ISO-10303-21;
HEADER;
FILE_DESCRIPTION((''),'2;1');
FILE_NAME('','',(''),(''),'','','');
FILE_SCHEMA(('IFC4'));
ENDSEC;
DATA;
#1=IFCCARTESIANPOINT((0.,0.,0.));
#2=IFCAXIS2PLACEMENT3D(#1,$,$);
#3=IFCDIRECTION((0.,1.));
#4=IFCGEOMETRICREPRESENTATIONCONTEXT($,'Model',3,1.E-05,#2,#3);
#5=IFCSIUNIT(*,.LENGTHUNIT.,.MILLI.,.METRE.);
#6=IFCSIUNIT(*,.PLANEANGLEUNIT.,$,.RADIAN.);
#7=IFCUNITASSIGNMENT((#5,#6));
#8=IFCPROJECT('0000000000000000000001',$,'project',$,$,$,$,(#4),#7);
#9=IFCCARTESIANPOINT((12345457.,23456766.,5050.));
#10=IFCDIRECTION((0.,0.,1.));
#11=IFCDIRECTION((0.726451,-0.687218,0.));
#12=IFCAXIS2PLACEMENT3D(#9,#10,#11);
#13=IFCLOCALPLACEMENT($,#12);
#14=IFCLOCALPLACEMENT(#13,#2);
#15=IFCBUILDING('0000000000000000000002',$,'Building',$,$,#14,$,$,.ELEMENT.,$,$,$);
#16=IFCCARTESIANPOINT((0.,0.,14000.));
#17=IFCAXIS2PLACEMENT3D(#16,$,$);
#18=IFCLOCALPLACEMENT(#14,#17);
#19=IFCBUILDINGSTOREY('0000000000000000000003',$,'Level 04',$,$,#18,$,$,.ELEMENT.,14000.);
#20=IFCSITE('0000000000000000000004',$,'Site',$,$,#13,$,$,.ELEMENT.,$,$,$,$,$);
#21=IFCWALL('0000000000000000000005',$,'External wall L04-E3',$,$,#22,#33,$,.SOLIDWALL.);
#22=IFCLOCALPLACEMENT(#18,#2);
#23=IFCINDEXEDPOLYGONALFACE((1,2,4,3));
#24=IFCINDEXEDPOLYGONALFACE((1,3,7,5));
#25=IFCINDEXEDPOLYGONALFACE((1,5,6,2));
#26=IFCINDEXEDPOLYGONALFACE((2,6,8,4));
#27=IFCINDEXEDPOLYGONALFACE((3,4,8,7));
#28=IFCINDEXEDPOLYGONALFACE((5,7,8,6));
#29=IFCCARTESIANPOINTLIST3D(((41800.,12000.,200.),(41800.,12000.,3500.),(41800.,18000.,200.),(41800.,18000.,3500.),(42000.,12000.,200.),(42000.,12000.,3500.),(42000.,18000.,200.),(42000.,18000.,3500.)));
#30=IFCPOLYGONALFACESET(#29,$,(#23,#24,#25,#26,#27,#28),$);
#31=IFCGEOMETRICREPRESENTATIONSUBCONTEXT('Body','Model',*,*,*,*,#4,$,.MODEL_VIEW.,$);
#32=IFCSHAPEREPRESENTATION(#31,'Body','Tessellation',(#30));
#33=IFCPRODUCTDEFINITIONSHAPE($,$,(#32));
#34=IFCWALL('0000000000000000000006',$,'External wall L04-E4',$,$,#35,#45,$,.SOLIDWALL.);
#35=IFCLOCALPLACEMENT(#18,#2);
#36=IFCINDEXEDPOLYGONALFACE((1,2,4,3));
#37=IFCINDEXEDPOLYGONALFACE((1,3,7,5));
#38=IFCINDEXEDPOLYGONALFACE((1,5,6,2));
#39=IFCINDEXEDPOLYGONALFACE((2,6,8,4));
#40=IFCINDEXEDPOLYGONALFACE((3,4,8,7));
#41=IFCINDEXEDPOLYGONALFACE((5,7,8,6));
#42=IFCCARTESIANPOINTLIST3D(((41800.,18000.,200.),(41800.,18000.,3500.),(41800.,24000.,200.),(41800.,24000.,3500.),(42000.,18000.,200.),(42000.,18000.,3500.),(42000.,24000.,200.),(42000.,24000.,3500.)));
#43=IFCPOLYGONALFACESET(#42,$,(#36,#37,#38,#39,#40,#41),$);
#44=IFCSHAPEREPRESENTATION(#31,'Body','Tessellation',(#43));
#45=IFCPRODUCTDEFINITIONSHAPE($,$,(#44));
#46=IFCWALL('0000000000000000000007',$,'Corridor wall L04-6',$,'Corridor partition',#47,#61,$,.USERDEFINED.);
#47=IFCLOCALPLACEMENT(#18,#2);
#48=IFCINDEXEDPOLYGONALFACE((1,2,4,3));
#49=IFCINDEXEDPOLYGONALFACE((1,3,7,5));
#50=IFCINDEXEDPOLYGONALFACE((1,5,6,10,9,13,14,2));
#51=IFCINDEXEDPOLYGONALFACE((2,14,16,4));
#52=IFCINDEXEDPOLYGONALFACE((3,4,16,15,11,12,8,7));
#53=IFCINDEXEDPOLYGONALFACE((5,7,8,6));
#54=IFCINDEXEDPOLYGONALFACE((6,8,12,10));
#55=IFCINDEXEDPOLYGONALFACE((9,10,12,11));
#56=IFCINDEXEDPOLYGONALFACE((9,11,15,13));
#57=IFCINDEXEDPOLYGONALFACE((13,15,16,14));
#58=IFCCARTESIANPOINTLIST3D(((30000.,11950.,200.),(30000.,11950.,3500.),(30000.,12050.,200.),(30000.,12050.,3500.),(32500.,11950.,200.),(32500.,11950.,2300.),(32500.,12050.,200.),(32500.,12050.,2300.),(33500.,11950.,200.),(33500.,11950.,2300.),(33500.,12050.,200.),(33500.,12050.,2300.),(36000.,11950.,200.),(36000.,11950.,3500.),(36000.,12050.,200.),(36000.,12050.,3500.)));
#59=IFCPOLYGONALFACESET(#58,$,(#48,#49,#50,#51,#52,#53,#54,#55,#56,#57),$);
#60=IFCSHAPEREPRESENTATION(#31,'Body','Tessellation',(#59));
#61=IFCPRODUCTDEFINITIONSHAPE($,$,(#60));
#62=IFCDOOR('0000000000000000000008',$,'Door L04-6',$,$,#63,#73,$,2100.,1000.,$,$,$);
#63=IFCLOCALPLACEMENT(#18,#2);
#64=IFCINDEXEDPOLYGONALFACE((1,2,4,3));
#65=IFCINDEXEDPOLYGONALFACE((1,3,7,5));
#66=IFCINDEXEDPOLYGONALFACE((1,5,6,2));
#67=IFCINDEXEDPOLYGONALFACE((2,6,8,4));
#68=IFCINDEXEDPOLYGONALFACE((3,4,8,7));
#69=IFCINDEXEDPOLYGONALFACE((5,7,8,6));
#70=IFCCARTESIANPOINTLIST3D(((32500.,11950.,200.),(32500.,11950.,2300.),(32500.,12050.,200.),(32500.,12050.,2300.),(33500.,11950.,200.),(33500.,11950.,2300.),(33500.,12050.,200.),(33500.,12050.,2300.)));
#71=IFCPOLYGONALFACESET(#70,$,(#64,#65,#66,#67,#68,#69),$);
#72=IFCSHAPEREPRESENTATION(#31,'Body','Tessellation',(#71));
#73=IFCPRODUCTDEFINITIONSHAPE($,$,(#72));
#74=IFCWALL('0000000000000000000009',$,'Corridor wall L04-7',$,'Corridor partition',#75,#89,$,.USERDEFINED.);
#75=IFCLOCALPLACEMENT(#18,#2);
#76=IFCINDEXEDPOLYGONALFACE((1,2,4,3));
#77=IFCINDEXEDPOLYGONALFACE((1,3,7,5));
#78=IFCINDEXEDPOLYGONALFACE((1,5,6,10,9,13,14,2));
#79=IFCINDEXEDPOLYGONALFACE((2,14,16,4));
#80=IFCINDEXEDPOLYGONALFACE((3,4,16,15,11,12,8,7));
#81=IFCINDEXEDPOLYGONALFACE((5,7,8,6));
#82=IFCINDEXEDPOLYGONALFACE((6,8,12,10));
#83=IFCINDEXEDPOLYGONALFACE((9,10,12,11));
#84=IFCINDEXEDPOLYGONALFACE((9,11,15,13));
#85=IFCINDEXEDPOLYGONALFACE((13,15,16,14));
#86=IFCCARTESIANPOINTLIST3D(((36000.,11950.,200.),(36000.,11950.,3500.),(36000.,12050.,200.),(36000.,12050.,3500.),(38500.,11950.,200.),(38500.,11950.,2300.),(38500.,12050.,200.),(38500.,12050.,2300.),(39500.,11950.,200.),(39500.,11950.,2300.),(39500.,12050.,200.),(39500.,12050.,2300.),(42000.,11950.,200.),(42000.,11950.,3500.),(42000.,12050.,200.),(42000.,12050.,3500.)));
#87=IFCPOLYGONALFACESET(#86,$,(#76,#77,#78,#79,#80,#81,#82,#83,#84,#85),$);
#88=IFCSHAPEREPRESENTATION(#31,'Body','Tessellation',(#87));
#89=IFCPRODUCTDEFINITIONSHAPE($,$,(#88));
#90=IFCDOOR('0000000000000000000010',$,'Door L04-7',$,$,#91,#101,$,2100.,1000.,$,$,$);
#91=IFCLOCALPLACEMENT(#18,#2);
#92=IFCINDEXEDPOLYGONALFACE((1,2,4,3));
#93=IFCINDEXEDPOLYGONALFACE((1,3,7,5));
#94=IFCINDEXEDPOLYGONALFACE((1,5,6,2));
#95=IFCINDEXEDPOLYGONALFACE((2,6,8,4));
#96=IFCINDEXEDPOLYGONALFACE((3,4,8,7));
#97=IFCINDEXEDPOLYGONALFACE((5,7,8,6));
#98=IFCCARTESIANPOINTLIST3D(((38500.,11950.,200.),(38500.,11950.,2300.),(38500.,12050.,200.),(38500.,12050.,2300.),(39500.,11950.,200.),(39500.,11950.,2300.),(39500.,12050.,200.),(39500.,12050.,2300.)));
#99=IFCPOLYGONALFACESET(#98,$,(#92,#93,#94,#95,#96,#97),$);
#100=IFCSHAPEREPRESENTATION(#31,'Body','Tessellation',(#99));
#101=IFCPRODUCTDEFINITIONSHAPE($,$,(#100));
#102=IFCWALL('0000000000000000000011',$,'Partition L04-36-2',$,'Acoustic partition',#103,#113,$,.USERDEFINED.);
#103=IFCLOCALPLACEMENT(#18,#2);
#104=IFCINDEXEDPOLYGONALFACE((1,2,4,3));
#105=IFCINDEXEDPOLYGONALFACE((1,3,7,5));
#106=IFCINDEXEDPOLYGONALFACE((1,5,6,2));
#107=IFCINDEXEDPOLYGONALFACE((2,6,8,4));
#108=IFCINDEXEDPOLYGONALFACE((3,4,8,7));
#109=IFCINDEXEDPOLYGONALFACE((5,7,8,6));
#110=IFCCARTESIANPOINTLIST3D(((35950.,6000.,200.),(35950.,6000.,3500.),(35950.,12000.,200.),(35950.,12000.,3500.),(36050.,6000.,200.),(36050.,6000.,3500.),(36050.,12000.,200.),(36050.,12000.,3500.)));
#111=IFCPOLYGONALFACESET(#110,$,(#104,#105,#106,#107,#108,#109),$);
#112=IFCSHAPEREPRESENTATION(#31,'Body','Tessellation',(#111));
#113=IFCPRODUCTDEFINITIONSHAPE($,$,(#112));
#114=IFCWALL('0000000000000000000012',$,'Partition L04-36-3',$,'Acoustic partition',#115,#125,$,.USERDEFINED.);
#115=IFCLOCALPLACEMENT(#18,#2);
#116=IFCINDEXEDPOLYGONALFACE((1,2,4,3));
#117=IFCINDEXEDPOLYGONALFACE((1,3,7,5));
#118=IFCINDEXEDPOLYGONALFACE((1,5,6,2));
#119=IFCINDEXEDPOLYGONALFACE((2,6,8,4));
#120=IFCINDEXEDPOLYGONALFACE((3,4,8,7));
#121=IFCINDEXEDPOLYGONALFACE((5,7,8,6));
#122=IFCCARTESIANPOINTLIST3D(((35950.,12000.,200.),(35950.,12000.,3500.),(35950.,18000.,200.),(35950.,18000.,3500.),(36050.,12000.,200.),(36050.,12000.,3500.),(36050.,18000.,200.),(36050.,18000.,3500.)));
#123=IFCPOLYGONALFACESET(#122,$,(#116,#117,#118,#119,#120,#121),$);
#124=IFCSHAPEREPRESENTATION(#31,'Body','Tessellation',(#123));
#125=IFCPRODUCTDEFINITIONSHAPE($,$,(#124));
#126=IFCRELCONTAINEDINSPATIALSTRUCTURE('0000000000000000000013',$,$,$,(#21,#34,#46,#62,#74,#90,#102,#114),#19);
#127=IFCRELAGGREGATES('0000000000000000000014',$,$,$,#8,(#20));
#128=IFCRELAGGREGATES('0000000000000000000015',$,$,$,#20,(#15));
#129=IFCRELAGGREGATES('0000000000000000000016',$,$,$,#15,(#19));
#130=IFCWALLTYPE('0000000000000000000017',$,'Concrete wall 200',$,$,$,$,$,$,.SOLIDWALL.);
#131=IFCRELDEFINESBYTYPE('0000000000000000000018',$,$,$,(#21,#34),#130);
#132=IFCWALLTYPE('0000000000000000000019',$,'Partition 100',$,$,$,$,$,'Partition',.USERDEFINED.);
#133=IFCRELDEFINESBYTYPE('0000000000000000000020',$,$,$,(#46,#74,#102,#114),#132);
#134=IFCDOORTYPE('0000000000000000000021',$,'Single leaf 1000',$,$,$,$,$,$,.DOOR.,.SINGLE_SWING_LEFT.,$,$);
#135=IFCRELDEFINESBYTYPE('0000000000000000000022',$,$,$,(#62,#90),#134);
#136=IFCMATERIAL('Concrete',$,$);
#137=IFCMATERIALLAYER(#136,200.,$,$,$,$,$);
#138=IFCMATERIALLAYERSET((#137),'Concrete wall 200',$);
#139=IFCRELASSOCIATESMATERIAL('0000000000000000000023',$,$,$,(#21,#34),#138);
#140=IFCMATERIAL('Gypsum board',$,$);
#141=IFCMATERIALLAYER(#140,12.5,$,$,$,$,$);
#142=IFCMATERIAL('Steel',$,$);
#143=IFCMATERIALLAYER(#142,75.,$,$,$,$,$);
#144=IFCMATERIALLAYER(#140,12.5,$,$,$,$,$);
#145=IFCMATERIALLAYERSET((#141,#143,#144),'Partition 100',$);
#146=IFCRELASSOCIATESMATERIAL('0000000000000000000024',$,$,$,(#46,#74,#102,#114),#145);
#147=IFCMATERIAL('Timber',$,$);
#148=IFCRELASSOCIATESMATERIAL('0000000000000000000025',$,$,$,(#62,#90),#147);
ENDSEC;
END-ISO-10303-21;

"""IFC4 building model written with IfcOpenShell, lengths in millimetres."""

from ifc_helpers import new_model, si_unit, direction, frame, origin, place, context, subcontext, project, spatial, rectangle, extrude, source, transform, mapped, material, layer, layer_set, layer_usage, type_object, type_shapes, element, fill, save


model = new_model("IFC4")

# Units and contexts
model_context = context("Model", 3, precision=1e-05, world=origin(), true_north=direction((0.0, 1.0)))
body_context = subcontext(model_context, "Body", "Model", "MODEL_VIEW")
ifc_project = project(units=[si_unit("LENGTHUNIT", "METRE", prefix="MILLI"), si_unit("PLANEANGLEUNIT", "RADIAN")], contexts=[model_context])

# Site, building, storey
site_placement = place(None, frame((12345457.0, 23456766.0, 5050.0), z_axis=(0.0, 0.0, 1.0), x_axis=(0.726451, -0.687218, 0.0)))
site = spatial("IfcSite", under=ifc_project, at=site_placement, Name="Site", CompositionType="ELEMENT")
building_placement = place(site_placement, origin())
building = spatial("IfcBuilding", under=site, at=building_placement, Name="Building", CompositionType="ELEMENT")
storey_placement = place(building_placement, frame((0.0, 0.0, 14000.0)))
storey = spatial("IfcBuildingStorey", under=building, at=storey_placement, Name="Level 04", CompositionType="ELEMENT", Elevation=14000.0)

# Shared definitions
ifc_material_1 = material(Name="Steel")

# Shared definitions
ifc_material_2 = material(Name="Concrete")

# Walls
ifc_layer_1 = layer(ifc_material_2, 200.0)
ifc_layer_set_1 = layer_set([ifc_layer_1], Name="Concrete wall 200")
ifc_layer_usage_1 = layer_usage(ifc_layer_set_1, "AXIS2", "POSITIVE", 0.0)
wall_type_1 = type_object("IfcWallType", Name="Concrete wall 200", PredefinedType="SOLIDWALL")
for number, where, name in (
    (1, (41800.0, 12000.0, 200.0), "External wall L04-E3"),
    (2, (41800.0, 18000.0, 200.0), "External wall L04-E4"),
):
    element("IfcWall", number, at=place(storey_placement, frame(where)), inside=storey, type_object=wall_type_1, material=ifc_layer_usage_1, Name=name, PredefinedType="SOLIDWALL", context=body_context, shape_type="SweptSolid", body=[
        extrude(rectangle(XDim=200.0, YDim=6000.0), frame((100.0, 3000.0, 0.0)), (0.0, 0.0, 1.0), 3300.0),
    ])

# Walls, openings, doors
ifc_material_3 = material(Name="Gypsum board")
ifc_layer_2 = layer(ifc_material_3, 12.5)
ifc_layer_3 = layer(ifc_material_1, 75.0)
ifc_layer_4 = layer(ifc_material_3, 12.5)
ifc_layer_set_2 = layer_set([ifc_layer_2, ifc_layer_3, ifc_layer_4], Name="Partition 100")
ifc_layer_usage_2 = layer_usage(ifc_layer_set_2, "AXIS2", "POSITIVE", 0.0)
wall_type_2 = type_object("IfcWallType", Name="Partition 100", ElementType="Partition", PredefinedType="USERDEFINED")
wall_1_placement = place(storey_placement, frame((30000.0, 11950.0, 200.0)))
wall_1 = element("IfcWall", 3, at=wall_1_placement, inside=storey, type_object=wall_type_2, material=ifc_layer_usage_2, Name="Corridor wall L04-6", ObjectType="Corridor partition", PredefinedType="USERDEFINED", context=body_context, shape_type="SweptSolid", body=[
    extrude(rectangle(XDim=6000.0, YDim=100.0), frame((3000.0, 50.0, 0.0)), (0.0, 0.0, 1.0), 3300.0),
])
opening_1_placement = place(wall_1_placement, frame((2500.0, -50.0, 0.0)))
opening_1 = element("IfcOpeningElement", 4, at=opening_1_placement, cuts=wall_1, PredefinedType="OPENING", context=body_context, shape_type="SweptSolid", body=[
    extrude(rectangle(XDim=1000.0, YDim=200.0), frame((500.0, 100.0, 0.0)), (0.0, 0.0, 1.0), 2100.0),
])
ifc_material_4 = material(Name="Timber")
door_type = type_object("IfcDoorType", Name="Single leaf 1000", OperationType="SINGLE_SWING_LEFT", PredefinedType="DOOR")
shared_shape = source(origin(), body_context, "Body", "SweptSolid", [
    extrude(rectangle(XDim=1000.0, YDim=100.0), frame((500.0, 50.0, 0.0)), (0.0, 0.0, 1.0), 2100.0),
])
type_shapes(door_type, [shared_shape])
door_1_placement = place(storey_placement, frame((32500.0, 11950.0, 200.0)))
door_1 = element("IfcDoor", 5, at=door_1_placement, inside=storey, type_object=door_type, material=ifc_material_4, Name="Door L04-6", OverallHeight=2100.0, OverallWidth=1000.0, context=body_context, shape_type="MappedRepresentation", body=[
    mapped(shared_shape, transform((0.0, 0.0, 0.0))),
])
fill(opening_1, door_1)
wall_2_placement = place(storey_placement, frame((36000.0, 11950.0, 200.0)))
wall_2 = element("IfcWall", 6, at=wall_2_placement, inside=storey, type_object=wall_type_2, material=ifc_layer_usage_2, Name="Corridor wall L04-7", ObjectType="Corridor partition", PredefinedType="USERDEFINED", context=body_context, shape_type="SweptSolid", body=[
    extrude(rectangle(XDim=6000.0, YDim=100.0), frame((3000.0, 50.0, 0.0)), (0.0, 0.0, 1.0), 3300.0),
])
opening_2_placement = place(wall_2_placement, frame((2500.0, -50.0, 0.0)))
opening_2 = element("IfcOpeningElement", 7, at=opening_2_placement, cuts=wall_2, PredefinedType="OPENING", context=body_context, shape_type="SweptSolid", body=[
    extrude(rectangle(XDim=1000.0, YDim=200.0), frame((500.0, 100.0, 0.0)), (0.0, 0.0, 1.0), 2100.0),
])
door_2_placement = place(storey_placement, frame((38500.0, 11950.0, 200.0)))
door_2 = element("IfcDoor", 8, at=door_2_placement, inside=storey, type_object=door_type, material=ifc_material_4, Name="Door L04-7", OverallHeight=2100.0, OverallWidth=1000.0, context=body_context, shape_type="MappedRepresentation", body=[
    mapped(shared_shape, transform((0.0, 0.0, 0.0))),
])
fill(opening_2, door_2)

# Walls
for number, where, name in (
    (9, (35950.0, 6000.0, 200.0), "Partition L04-36-2"),
    (10, (35950.0, 12000.0, 200.0), "Partition L04-36-3"),
):
    element("IfcWall", number, at=place(storey_placement, frame(where)), inside=storey, type_object=wall_type_2, material=ifc_layer_usage_2, Name=name, ObjectType="Acoustic partition", PredefinedType="USERDEFINED", context=body_context, shape_type="SweptSolid", body=[
        extrude(rectangle(XDim=100.0, YDim=6000.0), frame((50.0, 3000.0, 0.0)), (0.0, 0.0, 1.0), 3300.0),
    ])

save(model, "model.ifc")
